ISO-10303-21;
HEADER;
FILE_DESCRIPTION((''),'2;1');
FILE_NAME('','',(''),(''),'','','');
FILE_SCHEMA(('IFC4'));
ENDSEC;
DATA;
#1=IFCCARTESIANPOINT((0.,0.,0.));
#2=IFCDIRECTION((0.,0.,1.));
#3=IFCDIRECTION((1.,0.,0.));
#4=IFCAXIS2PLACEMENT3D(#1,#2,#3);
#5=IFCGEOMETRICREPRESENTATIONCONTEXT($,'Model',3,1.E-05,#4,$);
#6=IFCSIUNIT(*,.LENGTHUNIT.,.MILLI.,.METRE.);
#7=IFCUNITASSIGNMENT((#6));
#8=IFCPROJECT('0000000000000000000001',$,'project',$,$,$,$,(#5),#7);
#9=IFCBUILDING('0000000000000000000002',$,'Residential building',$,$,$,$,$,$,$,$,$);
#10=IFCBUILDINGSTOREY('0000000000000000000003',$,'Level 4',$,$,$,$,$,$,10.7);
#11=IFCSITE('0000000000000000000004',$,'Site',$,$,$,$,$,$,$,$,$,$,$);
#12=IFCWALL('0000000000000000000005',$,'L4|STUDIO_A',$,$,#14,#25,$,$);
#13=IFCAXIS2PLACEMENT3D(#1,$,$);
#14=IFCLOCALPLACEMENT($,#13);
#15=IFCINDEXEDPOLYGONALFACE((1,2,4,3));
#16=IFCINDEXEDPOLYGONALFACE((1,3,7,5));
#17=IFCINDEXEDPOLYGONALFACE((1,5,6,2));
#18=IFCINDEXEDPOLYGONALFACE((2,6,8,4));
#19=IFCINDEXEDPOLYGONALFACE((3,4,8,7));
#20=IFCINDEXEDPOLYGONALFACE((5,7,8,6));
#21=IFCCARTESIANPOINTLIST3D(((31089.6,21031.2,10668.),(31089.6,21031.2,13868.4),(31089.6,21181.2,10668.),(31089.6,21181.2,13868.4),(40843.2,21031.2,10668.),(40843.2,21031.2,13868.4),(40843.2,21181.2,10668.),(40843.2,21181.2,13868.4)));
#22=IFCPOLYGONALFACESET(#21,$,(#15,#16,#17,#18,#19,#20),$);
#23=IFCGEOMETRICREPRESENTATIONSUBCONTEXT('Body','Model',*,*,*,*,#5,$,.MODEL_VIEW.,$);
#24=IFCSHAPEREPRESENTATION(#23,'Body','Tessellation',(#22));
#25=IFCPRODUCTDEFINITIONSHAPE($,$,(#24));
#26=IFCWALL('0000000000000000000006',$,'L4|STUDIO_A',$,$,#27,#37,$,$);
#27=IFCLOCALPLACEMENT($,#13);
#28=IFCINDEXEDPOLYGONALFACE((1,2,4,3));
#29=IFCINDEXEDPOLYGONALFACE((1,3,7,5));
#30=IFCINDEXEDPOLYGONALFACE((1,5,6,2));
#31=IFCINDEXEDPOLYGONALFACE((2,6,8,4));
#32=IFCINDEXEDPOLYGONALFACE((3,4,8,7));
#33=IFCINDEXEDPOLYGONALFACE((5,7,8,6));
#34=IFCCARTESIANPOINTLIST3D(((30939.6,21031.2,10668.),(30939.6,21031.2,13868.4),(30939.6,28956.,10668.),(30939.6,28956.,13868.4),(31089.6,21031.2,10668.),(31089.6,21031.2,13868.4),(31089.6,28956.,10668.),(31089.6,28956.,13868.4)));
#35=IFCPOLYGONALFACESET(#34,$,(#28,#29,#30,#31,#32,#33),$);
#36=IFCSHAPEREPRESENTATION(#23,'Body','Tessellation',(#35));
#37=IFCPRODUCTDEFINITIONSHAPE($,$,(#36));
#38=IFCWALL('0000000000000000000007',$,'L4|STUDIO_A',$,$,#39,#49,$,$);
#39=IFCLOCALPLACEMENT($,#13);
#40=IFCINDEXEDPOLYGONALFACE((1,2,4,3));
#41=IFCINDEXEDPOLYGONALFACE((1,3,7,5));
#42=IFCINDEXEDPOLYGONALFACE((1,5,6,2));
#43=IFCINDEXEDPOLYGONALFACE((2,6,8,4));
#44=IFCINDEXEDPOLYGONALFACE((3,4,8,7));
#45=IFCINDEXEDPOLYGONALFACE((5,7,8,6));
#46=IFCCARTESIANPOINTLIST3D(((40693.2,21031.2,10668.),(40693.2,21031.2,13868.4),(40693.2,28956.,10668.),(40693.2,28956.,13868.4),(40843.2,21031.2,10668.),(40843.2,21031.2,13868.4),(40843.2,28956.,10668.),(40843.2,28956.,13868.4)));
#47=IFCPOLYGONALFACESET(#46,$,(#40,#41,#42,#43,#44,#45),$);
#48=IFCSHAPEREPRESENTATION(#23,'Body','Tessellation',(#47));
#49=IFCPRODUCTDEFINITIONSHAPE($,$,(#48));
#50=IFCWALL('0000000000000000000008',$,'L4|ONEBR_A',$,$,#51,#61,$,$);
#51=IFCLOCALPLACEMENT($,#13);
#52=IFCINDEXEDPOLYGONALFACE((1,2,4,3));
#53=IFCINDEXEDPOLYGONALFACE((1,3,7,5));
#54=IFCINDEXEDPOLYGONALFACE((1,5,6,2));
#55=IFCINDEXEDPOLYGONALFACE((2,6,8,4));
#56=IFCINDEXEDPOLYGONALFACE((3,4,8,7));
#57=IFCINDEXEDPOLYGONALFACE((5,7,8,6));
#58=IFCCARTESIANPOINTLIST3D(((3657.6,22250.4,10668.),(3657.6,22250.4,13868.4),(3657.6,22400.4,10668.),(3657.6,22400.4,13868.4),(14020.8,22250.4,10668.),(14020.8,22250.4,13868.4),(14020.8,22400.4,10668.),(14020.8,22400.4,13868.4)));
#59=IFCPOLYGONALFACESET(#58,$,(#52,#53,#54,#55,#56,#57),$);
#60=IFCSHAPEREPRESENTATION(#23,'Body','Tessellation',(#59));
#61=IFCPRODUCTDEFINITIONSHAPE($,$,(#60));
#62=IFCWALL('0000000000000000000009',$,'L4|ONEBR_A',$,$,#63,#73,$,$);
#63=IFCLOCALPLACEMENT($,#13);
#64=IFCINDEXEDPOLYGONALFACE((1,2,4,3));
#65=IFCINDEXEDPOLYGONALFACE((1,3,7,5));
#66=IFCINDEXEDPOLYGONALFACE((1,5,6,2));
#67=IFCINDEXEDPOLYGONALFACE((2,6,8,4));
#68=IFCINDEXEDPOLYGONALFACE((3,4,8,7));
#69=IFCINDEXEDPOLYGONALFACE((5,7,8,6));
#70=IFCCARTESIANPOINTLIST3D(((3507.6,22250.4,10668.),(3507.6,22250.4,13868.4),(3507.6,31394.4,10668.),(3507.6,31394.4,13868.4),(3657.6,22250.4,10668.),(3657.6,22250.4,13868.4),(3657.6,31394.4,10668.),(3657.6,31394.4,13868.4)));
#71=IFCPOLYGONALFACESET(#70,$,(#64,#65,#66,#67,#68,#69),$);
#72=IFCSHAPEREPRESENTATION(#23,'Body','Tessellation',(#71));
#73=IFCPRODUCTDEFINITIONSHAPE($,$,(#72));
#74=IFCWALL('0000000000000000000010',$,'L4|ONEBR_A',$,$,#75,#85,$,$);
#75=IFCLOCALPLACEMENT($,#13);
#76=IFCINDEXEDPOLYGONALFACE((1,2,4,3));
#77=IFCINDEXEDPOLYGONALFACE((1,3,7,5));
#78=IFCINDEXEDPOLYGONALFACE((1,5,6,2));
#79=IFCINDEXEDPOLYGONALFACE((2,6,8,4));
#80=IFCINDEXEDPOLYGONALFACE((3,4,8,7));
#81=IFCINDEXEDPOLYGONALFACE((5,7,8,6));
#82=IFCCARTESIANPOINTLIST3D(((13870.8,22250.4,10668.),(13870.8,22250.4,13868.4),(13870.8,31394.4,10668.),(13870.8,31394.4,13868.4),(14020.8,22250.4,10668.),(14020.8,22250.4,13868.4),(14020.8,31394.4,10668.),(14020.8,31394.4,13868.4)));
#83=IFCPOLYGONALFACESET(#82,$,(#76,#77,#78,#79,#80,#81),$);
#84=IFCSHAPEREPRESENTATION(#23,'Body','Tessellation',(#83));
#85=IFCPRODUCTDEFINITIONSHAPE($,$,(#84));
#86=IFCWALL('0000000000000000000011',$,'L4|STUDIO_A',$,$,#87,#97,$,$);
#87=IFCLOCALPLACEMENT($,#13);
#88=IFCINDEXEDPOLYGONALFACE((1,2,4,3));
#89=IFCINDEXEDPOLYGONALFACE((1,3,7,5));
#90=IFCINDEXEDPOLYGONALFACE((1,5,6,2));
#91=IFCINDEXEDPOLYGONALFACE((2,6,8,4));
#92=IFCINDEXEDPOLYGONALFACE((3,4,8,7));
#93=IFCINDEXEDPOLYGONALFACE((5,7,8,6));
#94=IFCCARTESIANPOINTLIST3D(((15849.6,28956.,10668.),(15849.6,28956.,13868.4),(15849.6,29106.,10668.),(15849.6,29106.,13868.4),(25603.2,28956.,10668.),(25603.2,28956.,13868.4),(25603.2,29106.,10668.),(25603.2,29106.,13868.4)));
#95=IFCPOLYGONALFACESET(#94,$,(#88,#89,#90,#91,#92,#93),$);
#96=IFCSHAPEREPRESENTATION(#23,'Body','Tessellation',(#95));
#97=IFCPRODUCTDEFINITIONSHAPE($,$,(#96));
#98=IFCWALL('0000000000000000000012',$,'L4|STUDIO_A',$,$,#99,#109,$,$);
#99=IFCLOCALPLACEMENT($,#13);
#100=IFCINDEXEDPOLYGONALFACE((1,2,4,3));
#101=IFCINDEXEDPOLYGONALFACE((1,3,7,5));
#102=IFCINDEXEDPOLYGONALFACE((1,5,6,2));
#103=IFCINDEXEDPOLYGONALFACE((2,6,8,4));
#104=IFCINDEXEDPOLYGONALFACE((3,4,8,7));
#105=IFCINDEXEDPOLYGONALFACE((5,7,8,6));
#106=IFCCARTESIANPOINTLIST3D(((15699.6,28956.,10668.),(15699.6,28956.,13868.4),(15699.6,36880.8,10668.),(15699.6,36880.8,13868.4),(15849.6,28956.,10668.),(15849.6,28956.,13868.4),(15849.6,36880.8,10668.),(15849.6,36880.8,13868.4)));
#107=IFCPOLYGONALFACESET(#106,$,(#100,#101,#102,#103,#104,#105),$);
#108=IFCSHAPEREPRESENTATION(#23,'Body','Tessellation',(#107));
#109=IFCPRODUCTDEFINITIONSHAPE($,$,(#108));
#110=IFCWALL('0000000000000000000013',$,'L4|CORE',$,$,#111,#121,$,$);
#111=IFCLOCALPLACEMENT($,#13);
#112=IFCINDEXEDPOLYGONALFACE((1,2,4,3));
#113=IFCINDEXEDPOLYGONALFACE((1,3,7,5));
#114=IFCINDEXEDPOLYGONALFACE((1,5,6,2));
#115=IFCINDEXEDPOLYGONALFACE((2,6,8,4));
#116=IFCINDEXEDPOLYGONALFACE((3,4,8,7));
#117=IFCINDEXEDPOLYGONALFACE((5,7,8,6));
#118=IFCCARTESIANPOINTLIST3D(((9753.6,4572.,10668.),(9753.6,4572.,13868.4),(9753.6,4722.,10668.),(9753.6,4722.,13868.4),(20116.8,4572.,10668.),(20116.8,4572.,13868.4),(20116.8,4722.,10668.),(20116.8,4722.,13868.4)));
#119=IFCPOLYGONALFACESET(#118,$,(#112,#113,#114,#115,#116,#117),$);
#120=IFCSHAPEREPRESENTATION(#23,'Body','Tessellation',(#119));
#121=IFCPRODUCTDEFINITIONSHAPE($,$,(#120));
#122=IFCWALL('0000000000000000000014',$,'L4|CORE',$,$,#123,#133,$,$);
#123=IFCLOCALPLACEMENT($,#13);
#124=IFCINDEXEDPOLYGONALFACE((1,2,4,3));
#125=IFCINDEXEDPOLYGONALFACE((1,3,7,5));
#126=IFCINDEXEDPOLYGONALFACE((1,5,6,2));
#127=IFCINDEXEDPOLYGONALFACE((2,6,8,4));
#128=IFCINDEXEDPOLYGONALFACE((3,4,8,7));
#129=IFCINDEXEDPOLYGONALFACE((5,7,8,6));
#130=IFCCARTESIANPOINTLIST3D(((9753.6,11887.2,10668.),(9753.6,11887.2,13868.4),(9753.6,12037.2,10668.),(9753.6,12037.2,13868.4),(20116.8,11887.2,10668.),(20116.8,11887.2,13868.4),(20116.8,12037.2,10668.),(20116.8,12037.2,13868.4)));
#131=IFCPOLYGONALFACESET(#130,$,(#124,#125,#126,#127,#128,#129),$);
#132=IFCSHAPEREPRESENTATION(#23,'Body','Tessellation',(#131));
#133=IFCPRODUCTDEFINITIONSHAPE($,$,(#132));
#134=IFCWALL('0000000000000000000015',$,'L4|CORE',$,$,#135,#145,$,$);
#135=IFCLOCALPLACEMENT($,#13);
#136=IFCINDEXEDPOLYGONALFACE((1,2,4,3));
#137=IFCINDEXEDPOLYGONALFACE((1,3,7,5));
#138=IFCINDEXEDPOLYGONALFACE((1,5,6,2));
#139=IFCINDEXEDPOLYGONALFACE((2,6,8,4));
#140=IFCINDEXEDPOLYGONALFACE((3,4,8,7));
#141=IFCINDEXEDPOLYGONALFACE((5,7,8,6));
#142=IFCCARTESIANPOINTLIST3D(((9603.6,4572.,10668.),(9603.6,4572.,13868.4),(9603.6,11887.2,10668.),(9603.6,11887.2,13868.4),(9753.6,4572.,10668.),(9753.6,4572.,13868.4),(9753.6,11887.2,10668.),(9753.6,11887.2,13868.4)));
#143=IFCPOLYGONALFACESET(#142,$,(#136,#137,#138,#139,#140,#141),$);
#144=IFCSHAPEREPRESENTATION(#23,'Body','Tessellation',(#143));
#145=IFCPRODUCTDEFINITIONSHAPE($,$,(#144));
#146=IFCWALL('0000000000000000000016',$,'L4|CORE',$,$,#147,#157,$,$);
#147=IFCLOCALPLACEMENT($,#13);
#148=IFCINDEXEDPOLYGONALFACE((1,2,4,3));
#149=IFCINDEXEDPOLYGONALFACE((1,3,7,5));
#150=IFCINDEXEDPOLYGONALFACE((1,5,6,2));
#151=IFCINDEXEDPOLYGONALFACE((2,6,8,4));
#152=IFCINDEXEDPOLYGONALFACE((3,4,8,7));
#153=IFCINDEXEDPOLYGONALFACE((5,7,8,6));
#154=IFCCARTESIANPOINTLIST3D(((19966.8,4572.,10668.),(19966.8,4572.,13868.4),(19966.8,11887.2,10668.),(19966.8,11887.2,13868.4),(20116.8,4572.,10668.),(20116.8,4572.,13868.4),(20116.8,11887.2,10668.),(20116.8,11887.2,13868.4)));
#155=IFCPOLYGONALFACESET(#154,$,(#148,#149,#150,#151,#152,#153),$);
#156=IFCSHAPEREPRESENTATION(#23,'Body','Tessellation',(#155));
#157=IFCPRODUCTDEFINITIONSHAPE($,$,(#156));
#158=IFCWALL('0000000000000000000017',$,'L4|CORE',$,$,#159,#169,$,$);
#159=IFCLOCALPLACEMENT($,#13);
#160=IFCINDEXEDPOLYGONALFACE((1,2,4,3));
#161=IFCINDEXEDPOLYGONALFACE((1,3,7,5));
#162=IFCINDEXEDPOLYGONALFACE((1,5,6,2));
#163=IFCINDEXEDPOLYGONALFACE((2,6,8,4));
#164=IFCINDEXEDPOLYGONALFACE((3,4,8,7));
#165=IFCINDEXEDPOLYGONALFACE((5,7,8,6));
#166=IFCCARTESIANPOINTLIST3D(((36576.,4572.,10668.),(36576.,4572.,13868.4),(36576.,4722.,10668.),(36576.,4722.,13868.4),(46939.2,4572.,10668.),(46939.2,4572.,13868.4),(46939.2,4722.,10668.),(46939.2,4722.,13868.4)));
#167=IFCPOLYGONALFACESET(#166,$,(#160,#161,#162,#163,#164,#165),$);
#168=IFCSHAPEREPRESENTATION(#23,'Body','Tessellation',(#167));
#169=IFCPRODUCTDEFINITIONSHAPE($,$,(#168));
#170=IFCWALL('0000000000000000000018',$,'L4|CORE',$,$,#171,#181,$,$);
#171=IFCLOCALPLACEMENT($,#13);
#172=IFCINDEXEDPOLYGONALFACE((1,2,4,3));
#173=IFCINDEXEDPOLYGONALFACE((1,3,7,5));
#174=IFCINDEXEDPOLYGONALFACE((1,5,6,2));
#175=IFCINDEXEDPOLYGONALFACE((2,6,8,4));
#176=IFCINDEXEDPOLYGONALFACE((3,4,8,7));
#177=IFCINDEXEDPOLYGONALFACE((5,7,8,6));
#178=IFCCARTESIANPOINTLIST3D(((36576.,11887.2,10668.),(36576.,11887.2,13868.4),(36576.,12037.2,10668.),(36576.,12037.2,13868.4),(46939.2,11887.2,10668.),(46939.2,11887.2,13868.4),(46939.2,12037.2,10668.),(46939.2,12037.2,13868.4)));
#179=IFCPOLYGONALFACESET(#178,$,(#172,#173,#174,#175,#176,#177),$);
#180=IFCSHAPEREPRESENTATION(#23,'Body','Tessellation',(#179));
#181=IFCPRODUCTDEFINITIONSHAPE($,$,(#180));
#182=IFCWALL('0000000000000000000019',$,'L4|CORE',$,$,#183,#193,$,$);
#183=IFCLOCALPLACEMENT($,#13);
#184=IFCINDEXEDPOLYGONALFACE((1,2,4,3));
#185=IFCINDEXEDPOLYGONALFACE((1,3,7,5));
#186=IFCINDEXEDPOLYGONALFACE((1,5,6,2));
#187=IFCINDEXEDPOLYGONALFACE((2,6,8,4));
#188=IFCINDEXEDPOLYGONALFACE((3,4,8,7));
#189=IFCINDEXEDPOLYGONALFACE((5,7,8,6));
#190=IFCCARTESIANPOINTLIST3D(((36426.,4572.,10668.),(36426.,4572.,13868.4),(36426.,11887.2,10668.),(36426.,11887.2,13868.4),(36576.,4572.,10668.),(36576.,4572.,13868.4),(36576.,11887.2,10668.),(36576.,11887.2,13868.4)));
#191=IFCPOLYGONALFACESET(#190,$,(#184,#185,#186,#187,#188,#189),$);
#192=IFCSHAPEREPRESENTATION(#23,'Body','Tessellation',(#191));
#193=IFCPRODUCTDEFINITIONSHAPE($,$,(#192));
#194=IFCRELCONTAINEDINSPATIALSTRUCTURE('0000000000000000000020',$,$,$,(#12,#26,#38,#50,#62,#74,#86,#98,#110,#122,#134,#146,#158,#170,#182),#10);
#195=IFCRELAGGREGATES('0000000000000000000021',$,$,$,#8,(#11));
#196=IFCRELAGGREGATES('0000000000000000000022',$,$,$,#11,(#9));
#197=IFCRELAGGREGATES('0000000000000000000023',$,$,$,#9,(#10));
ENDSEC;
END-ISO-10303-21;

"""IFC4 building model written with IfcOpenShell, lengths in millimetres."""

from ifc_helpers import new_model, si_unit, frame, origin_with_axes, place, context, subcontext, project, spatial, indexed_curve, outline, extrude, element, save


model = new_model("IFC4")

# Units and contexts
model_context = context("Model", 3, precision=1e-05, world=origin_with_axes())
body_context = subcontext(model_context, "Body", "Model", "MODEL_VIEW")
ifc_project = project(units=[si_unit("LENGTHUNIT", "METRE", prefix="MILLI")], contexts=[model_context])

# Site, building, storey
site = spatial("IfcSite", under=ifc_project, Name="Site")
building = spatial("IfcBuilding", under=site, Name="Residential building")
storey = spatial("IfcBuildingStorey", under=building, Name="Level 4", Elevation=10.7)

# Walls
wall_1_placement = place(None, frame((31089.6, 21031.2, 10668.0), z_axis=(0.0, 0.0, 1.0), x_axis=(1.0, 0.0, 0.0)))
element("IfcWall", 1, at=wall_1_placement, inside=storey, Name="L4|STUDIO_A", context=body_context, shape_type="SweptSolid", body=[
    extrude(outline(indexed_curve([(0.0, 0.0), (0.0, 150.0), (9753.6, 150.0), (9753.6, 0.0), (0.0, 0.0)], self_intersect=False)), origin_with_axes(), (0.0, 0.0, 1.0), 3200.4),
])
for number, where, z_axis, x_axis, name in (
    (2, (31089.6, 21031.2, 10668.0), (0.0, 0.0, 1.0), (0.0, 1.0, 0.0), "L4|STUDIO_A"),
    (3, (40843.2, 21031.2, 10668.0), (0.0, 0.0, 1.0), (0.0, 1.0, 0.0), "L4|STUDIO_A"),
):
    element("IfcWall", number, at=place(None, frame(where, z_axis=z_axis, x_axis=x_axis)), inside=storey, Name=name, context=body_context, shape_type="SweptSolid", body=[
        extrude(outline(indexed_curve([(0.0, 0.0), (0.0, 150.0), (7924.8, 150.0), (7924.8, 0.0), (0.0, 0.0)], self_intersect=False)), origin_with_axes(), (0.0, 0.0, 1.0), 3200.4),
    ])
wall_2_placement = place(None, frame((3657.6, 22250.4, 10668.0), z_axis=(0.0, 0.0, 1.0), x_axis=(1.0, 0.0, 0.0)))
element("IfcWall", 4, at=wall_2_placement, inside=storey, Name="L4|ONEBR_A", context=body_context, shape_type="SweptSolid", body=[
    extrude(outline(indexed_curve([(0.0, 0.0), (0.0, 150.0), (10363.2, 150.0), (10363.2, 0.0), (0.0, 0.0)], self_intersect=False)), origin_with_axes(), (0.0, 0.0, 1.0), 3200.4),
])
for number, where, z_axis, x_axis, name in (
    (5, (3657.6, 22250.4, 10668.0), (0.0, 0.0, 1.0), (0.0, 1.0, 0.0), "L4|ONEBR_A"),
    (6, (14020.8, 22250.4, 10668.0), (0.0, 0.0, 1.0), (0.0, 1.0, 0.0), "L4|ONEBR_A"),
):
    element("IfcWall", number, at=place(None, frame(where, z_axis=z_axis, x_axis=x_axis)), inside=storey, Name=name, context=body_context, shape_type="SweptSolid", body=[
        extrude(outline(indexed_curve([(0.0, 0.0), (0.0, 150.0), (9144.0, 150.0), (9144.0, 0.0), (0.0, 0.0)], self_intersect=False)), origin_with_axes(), (0.0, 0.0, 1.0), 3200.4),
    ])
wall_3_placement = place(None, frame((15849.6, 28956.0, 10668.0), z_axis=(0.0, 0.0, 1.0), x_axis=(1.0, 0.0, 0.0)))
element("IfcWall", 7, at=wall_3_placement, inside=storey, Name="L4|STUDIO_A", context=body_context, shape_type="SweptSolid", body=[
    extrude(outline(indexed_curve([(0.0, 0.0), (0.0, 150.0), (9753.6, 150.0), (9753.6, 0.0), (0.0, 0.0)], self_intersect=False)), origin_with_axes(), (0.0, 0.0, 1.0), 3200.4),
])
wall_4_placement = place(None, frame((15849.6, 28956.0, 10668.0), z_axis=(0.0, 0.0, 1.0), x_axis=(0.0, 1.0, 0.0)))
element("IfcWall", 8, at=wall_4_placement, inside=storey, Name="L4|STUDIO_A", context=body_context, shape_type="SweptSolid", body=[
    extrude(outline(indexed_curve([(0.0, 0.0), (0.0, 150.0), (7924.8, 150.0), (7924.8, 0.0), (0.0, 0.0)], self_intersect=False)), origin_with_axes(), (0.0, 0.0, 1.0), 3200.4),
])
for number, where, z_axis, x_axis, name in (
    (9, (9753.6, 4572.0, 10668.0), (0.0, 0.0, 1.0), (1.0, 0.0, 0.0), "L4|CORE"),
    (10, (9753.6, 11887.2, 10668.0), (0.0, 0.0, 1.0), (1.0, 0.0, 0.0), "L4|CORE"),
):
    element("IfcWall", number, at=place(None, frame(where, z_axis=z_axis, x_axis=x_axis)), inside=storey, Name=name, context=body_context, shape_type="SweptSolid", body=[
        extrude(outline(indexed_curve([(0.0, 0.0), (0.0, 150.0), (10363.2, 150.0), (10363.2, 0.0), (0.0, 0.0)], self_intersect=False)), origin_with_axes(), (0.0, 0.0, 1.0), 3200.4),
    ])
for number, where, z_axis, x_axis, name in (
    (11, (9753.6, 4572.0, 10668.0), (0.0, 0.0, 1.0), (0.0, 1.0, 0.0), "L4|CORE"),
    (12, (20116.8, 4572.0, 10668.0), (0.0, 0.0, 1.0), (0.0, 1.0, 0.0), "L4|CORE"),
):
    element("IfcWall", number, at=place(None, frame(where, z_axis=z_axis, x_axis=x_axis)), inside=storey, Name=name, context=body_context, shape_type="SweptSolid", body=[
        extrude(outline(indexed_curve([(0.0, 0.0), (0.0, 150.0), (7315.2, 150.0), (7315.2, 0.0), (0.0, 0.0)], self_intersect=False)), origin_with_axes(), (0.0, 0.0, 1.0), 3200.4),
    ])
for number, where, z_axis, x_axis, name in (
    (13, (36576.0, 4572.0, 10668.0), (0.0, 0.0, 1.0), (1.0, 0.0, 0.0), "L4|CORE"),
    (14, (36576.0, 11887.2, 10668.0), (0.0, 0.0, 1.0), (1.0, 0.0, 0.0), "L4|CORE"),
):
    element("IfcWall", number, at=place(None, frame(where, z_axis=z_axis, x_axis=x_axis)), inside=storey, Name=name, context=body_context, shape_type="SweptSolid", body=[
        extrude(outline(indexed_curve([(0.0, 0.0), (0.0, 150.0), (10363.2, 150.0), (10363.2, 0.0), (0.0, 0.0)], self_intersect=False)), origin_with_axes(), (0.0, 0.0, 1.0), 3200.4),
    ])
wall_5_placement = place(None, frame((36576.0, 4572.0, 10668.0), z_axis=(0.0, 0.0, 1.0), x_axis=(0.0, 1.0, 0.0)))
element("IfcWall", 15, at=wall_5_placement, inside=storey, Name="L4|CORE", context=body_context, shape_type="SweptSolid", body=[
    extrude(outline(indexed_curve([(0.0, 0.0), (0.0, 150.0), (7315.2, 150.0), (7315.2, 0.0), (0.0, 0.0)], self_intersect=False)), origin_with_axes(), (0.0, 0.0, 1.0), 3200.4),
])

save(model, "model.ifc")
